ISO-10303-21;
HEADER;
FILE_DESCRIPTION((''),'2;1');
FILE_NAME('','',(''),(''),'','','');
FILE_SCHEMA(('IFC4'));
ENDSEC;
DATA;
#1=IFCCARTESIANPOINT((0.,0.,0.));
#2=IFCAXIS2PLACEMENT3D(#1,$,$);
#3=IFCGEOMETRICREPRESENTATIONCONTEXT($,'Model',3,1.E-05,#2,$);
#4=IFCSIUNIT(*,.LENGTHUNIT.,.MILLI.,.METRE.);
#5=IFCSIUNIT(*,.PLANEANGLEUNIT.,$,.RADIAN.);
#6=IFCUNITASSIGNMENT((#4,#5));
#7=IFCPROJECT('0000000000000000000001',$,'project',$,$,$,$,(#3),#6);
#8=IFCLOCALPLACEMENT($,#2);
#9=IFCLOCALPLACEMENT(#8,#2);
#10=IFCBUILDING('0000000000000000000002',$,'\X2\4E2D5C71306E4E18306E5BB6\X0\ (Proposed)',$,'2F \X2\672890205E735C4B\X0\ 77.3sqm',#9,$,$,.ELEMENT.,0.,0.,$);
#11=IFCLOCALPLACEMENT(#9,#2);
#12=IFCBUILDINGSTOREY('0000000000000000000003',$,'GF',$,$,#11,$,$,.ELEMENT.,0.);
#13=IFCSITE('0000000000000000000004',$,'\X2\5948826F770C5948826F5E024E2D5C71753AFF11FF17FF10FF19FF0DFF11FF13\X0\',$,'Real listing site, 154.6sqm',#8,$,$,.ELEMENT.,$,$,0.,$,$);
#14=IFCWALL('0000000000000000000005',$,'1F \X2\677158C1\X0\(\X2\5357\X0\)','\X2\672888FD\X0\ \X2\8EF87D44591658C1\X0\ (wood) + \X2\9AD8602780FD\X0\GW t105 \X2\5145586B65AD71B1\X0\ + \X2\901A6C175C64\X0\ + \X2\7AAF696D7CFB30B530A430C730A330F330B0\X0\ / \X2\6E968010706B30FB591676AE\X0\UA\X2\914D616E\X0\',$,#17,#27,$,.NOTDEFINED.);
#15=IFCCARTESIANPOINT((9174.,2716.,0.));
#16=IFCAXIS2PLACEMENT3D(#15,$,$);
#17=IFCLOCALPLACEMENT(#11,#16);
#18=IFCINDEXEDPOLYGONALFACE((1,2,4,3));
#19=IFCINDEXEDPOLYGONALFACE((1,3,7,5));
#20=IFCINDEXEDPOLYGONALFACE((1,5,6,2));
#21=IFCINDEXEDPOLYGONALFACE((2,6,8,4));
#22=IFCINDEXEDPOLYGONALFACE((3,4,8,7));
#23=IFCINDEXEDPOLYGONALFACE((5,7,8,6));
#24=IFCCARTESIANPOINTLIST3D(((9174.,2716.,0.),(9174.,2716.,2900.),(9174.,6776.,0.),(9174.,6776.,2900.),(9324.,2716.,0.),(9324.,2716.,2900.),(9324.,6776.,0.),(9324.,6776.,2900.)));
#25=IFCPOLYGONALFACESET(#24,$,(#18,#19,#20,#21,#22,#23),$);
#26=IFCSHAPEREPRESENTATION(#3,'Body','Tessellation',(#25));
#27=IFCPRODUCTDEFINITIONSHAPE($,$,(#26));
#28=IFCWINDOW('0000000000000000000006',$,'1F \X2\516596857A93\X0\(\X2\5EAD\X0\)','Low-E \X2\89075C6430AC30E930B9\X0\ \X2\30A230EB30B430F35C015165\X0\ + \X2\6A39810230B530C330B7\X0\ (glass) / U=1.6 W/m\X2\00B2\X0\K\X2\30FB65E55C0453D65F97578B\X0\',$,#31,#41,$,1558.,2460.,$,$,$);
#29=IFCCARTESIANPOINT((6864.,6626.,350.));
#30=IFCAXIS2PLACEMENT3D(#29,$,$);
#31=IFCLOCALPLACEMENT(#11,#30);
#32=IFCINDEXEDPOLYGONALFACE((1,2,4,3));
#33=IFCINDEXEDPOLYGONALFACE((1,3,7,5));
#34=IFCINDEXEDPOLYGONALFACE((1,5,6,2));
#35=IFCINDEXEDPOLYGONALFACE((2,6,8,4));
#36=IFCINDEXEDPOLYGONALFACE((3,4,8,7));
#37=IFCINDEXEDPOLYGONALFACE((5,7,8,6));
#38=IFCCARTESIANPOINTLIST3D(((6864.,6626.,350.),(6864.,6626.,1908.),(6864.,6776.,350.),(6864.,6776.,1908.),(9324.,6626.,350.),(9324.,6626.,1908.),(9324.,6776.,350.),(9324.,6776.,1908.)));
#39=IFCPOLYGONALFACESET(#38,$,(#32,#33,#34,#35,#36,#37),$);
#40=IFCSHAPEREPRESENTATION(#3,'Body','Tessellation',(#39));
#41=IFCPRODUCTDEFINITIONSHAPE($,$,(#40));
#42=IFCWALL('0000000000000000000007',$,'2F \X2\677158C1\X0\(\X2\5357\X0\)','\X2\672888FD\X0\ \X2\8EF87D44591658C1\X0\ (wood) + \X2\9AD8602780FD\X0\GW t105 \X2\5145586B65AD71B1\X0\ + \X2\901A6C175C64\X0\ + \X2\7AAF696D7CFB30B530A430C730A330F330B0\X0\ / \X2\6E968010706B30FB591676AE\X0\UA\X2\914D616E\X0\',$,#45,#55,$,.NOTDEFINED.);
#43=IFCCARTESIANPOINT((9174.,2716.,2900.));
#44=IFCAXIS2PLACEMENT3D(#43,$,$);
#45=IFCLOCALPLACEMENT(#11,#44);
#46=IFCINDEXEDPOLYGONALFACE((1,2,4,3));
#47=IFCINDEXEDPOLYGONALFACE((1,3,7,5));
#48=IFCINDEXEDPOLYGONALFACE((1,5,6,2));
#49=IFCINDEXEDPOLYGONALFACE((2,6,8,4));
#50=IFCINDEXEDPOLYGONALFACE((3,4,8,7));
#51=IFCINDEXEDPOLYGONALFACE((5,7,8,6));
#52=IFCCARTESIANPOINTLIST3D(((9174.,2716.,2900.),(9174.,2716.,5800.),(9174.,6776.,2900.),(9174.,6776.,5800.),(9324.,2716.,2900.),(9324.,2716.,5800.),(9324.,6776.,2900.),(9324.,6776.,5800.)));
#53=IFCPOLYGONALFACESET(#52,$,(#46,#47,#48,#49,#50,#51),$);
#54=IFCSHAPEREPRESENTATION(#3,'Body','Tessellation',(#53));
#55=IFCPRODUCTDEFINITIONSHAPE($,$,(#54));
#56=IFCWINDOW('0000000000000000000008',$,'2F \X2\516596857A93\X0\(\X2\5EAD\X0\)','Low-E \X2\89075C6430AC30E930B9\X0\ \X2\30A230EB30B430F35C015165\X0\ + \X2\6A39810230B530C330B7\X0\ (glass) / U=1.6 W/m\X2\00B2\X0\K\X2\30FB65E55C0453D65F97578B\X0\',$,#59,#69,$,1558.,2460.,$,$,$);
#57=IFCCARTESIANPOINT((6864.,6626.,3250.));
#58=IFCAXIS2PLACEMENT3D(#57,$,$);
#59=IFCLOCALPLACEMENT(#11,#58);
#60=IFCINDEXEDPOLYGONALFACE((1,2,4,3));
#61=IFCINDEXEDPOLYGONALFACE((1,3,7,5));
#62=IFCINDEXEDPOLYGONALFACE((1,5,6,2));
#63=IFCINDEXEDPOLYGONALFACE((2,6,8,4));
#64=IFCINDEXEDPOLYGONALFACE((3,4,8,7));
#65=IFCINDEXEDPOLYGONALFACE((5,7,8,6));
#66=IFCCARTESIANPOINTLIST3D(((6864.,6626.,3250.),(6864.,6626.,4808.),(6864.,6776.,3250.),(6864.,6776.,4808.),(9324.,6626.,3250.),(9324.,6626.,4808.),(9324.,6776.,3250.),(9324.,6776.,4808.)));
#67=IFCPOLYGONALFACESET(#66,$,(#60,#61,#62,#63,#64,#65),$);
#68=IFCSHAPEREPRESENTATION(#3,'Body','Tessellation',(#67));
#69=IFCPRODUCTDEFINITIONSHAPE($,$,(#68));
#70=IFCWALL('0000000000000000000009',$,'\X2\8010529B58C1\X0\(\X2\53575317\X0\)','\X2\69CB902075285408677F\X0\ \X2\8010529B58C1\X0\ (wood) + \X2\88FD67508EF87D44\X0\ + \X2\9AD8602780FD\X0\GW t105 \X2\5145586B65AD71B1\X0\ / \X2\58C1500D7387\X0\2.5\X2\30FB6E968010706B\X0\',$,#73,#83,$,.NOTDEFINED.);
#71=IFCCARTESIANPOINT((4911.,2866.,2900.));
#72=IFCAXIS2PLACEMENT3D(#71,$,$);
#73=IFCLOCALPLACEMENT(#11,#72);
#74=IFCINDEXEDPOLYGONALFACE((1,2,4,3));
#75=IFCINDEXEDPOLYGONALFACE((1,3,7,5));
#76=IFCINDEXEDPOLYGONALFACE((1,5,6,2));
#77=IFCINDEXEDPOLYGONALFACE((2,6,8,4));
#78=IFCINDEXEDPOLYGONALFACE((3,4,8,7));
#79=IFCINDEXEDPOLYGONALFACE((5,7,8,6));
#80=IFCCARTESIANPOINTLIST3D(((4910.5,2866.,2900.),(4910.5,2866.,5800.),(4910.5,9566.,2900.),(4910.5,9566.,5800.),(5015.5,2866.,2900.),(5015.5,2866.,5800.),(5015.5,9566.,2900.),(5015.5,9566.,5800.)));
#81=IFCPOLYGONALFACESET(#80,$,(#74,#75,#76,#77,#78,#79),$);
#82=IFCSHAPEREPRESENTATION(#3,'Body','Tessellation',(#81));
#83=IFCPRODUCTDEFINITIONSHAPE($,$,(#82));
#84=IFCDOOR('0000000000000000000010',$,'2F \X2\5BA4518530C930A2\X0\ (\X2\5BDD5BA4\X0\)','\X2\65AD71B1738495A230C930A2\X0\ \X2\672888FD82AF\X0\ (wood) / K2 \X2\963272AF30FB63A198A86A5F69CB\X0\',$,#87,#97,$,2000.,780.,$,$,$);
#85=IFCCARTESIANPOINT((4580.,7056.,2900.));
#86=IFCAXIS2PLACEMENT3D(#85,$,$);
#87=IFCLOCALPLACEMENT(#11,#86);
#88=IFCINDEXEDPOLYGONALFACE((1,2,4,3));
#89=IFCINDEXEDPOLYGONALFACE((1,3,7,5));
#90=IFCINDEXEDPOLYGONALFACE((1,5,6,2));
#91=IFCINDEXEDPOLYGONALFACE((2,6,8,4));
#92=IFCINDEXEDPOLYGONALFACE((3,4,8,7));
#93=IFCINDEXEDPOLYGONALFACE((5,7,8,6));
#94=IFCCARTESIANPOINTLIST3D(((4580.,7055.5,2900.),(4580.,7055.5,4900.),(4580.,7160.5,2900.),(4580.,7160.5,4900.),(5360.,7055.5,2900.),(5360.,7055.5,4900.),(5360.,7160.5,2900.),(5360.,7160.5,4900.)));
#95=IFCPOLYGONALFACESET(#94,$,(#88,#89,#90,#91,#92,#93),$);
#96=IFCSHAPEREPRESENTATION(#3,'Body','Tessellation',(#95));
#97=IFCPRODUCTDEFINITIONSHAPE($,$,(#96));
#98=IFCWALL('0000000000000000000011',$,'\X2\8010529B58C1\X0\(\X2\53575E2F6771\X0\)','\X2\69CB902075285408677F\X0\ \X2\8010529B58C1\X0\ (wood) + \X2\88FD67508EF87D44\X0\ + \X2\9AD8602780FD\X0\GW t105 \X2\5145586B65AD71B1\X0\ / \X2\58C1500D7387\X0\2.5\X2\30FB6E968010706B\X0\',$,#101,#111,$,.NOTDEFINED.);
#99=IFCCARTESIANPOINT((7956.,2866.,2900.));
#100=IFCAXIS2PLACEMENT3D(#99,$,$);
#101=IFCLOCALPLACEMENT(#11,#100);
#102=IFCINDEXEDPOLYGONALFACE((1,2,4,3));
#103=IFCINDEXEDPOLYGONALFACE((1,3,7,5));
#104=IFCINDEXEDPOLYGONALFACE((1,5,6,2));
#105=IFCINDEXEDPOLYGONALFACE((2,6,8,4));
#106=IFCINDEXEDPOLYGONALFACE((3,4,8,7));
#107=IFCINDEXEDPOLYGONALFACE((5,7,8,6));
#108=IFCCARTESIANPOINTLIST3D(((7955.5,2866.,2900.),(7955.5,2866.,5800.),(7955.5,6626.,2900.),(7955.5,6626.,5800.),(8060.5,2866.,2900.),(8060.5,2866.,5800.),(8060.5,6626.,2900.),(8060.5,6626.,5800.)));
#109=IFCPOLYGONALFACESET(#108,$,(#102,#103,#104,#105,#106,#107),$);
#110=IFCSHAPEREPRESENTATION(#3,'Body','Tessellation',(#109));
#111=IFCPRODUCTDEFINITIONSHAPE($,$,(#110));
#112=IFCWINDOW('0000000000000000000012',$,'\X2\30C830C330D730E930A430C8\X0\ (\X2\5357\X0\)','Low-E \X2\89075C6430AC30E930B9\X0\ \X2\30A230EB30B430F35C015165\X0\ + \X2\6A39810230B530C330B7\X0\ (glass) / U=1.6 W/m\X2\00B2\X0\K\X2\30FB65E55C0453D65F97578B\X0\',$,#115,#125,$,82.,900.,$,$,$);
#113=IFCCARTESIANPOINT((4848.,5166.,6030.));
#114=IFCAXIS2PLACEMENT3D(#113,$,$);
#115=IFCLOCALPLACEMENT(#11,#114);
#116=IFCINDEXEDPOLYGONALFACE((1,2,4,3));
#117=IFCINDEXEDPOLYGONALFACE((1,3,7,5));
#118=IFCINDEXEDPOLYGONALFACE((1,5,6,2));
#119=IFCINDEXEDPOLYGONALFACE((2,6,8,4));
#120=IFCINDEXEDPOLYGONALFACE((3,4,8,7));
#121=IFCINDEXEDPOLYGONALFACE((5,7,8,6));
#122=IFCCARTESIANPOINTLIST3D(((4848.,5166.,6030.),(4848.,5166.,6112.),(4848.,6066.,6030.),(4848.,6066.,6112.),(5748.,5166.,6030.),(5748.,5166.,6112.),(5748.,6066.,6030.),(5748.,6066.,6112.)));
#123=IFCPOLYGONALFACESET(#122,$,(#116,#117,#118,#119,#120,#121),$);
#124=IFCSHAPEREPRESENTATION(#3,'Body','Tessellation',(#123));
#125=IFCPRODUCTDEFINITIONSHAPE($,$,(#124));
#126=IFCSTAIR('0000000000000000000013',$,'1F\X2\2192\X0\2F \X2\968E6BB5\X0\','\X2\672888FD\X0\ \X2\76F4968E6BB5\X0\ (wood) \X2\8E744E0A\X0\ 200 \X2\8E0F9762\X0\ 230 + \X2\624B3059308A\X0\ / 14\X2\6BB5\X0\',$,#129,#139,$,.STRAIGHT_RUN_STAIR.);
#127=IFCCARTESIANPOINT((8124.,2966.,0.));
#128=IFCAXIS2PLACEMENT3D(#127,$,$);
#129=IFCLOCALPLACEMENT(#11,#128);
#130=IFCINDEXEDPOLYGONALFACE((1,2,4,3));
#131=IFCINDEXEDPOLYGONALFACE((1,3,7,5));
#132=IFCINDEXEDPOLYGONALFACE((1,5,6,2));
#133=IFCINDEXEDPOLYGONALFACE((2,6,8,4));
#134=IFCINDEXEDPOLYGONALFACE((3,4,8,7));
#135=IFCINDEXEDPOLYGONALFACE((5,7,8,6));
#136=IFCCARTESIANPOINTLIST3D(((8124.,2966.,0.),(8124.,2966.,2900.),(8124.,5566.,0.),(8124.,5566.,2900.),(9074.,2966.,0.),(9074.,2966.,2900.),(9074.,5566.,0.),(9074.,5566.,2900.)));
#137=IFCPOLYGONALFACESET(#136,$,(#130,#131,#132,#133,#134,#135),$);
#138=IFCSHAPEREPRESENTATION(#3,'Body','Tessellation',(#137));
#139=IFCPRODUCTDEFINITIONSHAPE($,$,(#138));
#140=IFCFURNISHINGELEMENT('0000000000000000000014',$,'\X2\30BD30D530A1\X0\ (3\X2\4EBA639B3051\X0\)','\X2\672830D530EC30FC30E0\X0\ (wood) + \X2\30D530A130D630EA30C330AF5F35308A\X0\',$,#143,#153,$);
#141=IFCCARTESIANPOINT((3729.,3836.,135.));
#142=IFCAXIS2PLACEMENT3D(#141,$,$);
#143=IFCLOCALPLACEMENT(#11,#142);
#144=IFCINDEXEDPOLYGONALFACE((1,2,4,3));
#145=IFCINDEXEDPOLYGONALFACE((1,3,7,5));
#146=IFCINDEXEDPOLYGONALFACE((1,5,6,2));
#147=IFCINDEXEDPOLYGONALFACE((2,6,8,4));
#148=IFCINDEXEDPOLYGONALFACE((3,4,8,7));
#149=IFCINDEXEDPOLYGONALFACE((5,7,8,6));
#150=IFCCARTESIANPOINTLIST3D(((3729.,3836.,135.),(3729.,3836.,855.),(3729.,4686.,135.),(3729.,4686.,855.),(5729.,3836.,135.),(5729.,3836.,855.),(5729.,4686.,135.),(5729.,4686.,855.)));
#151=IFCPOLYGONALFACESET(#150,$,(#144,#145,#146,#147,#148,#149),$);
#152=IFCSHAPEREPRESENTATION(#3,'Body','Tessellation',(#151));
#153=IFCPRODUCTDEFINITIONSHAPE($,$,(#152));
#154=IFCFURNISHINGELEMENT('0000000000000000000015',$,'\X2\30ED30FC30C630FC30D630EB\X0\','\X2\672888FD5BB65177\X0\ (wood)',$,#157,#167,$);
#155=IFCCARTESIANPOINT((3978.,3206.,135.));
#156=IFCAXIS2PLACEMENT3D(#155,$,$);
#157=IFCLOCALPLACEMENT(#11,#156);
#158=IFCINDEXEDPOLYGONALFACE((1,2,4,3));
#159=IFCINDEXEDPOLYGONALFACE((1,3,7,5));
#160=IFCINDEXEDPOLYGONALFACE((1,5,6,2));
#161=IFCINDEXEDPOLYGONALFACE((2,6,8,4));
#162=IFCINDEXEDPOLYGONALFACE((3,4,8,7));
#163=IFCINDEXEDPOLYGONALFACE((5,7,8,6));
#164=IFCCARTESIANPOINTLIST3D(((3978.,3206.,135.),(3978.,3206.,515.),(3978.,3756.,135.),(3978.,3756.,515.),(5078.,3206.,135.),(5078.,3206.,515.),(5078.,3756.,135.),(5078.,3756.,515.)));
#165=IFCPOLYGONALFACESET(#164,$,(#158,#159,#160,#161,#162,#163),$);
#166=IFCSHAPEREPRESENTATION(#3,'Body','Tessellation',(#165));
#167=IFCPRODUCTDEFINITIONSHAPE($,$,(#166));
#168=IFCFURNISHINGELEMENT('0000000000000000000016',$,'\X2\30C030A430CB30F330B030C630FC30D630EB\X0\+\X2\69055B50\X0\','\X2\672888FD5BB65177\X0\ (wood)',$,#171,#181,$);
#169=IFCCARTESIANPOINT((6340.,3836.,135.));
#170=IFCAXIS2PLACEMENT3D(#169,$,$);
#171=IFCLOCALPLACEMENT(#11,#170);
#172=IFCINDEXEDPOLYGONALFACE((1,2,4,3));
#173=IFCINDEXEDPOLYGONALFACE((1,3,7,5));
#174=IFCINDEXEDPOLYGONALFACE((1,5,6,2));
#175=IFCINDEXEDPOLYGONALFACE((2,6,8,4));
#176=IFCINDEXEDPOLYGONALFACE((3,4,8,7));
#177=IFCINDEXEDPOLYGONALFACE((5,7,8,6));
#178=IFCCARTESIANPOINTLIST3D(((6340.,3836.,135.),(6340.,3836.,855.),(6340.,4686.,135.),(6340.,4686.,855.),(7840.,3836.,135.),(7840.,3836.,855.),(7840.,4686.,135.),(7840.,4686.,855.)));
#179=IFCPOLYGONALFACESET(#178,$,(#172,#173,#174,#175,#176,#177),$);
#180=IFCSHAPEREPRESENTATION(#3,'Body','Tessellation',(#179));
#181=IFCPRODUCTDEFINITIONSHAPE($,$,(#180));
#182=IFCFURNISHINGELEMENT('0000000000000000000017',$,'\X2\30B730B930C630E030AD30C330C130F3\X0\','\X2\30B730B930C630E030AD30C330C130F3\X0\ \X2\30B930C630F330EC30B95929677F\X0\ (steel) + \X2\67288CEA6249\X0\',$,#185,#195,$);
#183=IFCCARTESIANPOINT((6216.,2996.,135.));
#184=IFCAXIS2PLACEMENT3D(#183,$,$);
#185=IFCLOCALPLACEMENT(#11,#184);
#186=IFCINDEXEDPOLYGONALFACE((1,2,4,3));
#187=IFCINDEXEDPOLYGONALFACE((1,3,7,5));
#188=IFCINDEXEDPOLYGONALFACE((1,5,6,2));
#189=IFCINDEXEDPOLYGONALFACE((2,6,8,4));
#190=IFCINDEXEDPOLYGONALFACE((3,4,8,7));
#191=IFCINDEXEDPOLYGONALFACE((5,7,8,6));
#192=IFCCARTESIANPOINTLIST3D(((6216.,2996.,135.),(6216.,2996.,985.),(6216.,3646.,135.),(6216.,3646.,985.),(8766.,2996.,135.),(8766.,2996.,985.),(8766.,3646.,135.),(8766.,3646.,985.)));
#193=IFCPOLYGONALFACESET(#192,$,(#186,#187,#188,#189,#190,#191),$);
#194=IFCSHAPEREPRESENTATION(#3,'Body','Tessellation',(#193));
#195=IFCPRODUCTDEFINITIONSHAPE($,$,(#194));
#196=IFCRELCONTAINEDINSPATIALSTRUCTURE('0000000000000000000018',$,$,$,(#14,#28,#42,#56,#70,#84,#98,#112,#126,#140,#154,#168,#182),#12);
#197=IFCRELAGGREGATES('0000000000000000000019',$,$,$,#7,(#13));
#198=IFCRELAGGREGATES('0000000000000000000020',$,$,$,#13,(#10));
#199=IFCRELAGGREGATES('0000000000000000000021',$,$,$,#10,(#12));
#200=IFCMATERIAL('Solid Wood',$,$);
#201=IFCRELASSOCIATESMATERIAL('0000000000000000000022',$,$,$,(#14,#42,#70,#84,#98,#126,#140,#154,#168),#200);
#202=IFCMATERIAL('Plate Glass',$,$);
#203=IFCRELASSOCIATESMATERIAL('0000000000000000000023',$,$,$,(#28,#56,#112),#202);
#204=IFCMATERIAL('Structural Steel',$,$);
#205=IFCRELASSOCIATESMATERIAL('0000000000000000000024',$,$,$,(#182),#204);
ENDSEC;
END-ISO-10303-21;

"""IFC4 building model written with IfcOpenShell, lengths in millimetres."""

from ifc_helpers import new_model, si_unit, frame, frame_2d, origin, place, context, project, spatial, rectangle, extrude, material, element, fill, save


model = new_model("IFC4")

# Units and contexts
model_context = context("Model", 3, precision=1e-05, world=origin())
ifc_project = project(units=[si_unit("LENGTHUNIT", "METRE", prefix="MILLI"), si_unit("PLANEANGLEUNIT", "RADIAN")], contexts=[model_context])

# Site, building, storey
site_placement = place(None, origin())
site = spatial("IfcSite", under=ifc_project, at=site_placement, Name="奈良県奈良市中山町１７０９－１３", ObjectType="Real listing site, 154.6sqm", CompositionType="ELEMENT", RefElevation=0.0)
building_placement = place(site_placement, origin())
building = spatial("IfcBuilding", under=site, at=building_placement, Name="中山の丘の家 (Proposed)", ObjectType="2F 木造平屋 77.3sqm", CompositionType="ELEMENT", ElevationOfRefHeight=0.0, ElevationOfTerrain=0.0)
storey_placement = place(building_placement, origin())
storey = spatial("IfcBuildingStorey", under=building, at=storey_placement, Name="GF", CompositionType="ELEMENT", Elevation=0.0)

# Wall, opening, window
ifc_material_1 = material(Name="Solid Wood")
wall_1_placement = place(storey_placement, frame((9174.0, 2716.0, 0.0)))
wall_1 = element("IfcWall", 1, at=wall_1_placement, inside=storey, material=ifc_material_1, Name="1F 東壁(南)", Description="木製 軸組外壁 (wood) + 高性能GW t105 充填断熱 + 通気層 + 窯業系サイディング / 準耐火・外皮UA配慮", PredefinedType="NOTDEFINED", context=model_context, shape_type="SweptSolid", body=[
    extrude(rectangle(XDim=150.0, YDim=4060.0, at=frame_2d((75.0, 2030.0))), frame((9174.0, 2716.0, 0.0)), (0.0, 0.0, 1.0), 2900.0),
])
opening_1_placement = place(storey_placement, frame((6864.0, 6626.0, 350.0)))
opening_1 = element("IfcOpeningElement", 2, at=opening_1_placement, cuts=wall_1, PredefinedType="NOTDEFINED", context=model_context, shape_type="SweptSolid", body=[
    extrude(rectangle(XDim=2460.0, YDim=150.0, at=frame_2d((1230.0, 75.0))), frame((6864.0, 6626.0, 350.0)), (0.0, 0.0, 1.0), 1558.0),
])
ifc_material_2 = material(Name="Plate Glass")
window_1_placement = place(storey_placement, frame((6864.0, 6626.0, 350.0)))
window_1 = element("IfcWindow", 3, at=window_1_placement, inside=storey, material=ifc_material_2, Name="1F 入隅窓(庭)", Description="Low-E 複層ガラス アルゴン封入 + 樹脂サッシ (glass) / U=1.6 W/m²K・日射取得型", OverallHeight=1558.0, OverallWidth=2460.0, context=model_context, shape_type="SweptSolid", body=[
    extrude(rectangle(XDim=2460.0, YDim=150.0, at=frame_2d((1230.0, 75.0))), frame((6864.0, 6626.0, 350.0)), (0.0, 0.0, 1.0), 1558.0),
])
fill(opening_1, window_1)

# Wall, opening, window
wall_2_placement = place(storey_placement, frame((9174.0, 2716.0, 2900.0)))
wall_2 = element("IfcWall", 4, at=wall_2_placement, inside=storey, material=ifc_material_1, Name="2F 東壁(南)", Description="木製 軸組外壁 (wood) + 高性能GW t105 充填断熱 + 通気層 + 窯業系サイディング / 準耐火・外皮UA配慮", PredefinedType="NOTDEFINED", context=model_context, shape_type="SweptSolid", body=[
    extrude(rectangle(XDim=150.0, YDim=4060.0, at=frame_2d((75.0, 2030.0))), frame((9174.0, 2716.0, 2900.0)), (0.0, 0.0, 1.0), 2900.0),
])
opening_2_placement = place(storey_placement, frame((6864.0, 6626.0, 3250.0)))
opening_2 = element("IfcOpeningElement", 5, at=opening_2_placement, cuts=wall_2, PredefinedType="NOTDEFINED", context=model_context, shape_type="SweptSolid", body=[
    extrude(rectangle(XDim=2460.0, YDim=150.0, at=frame_2d((1230.0, 75.0))), frame((6864.0, 6626.0, 3250.0)), (0.0, 0.0, 1.0), 1558.0),
])
window_2_placement = place(storey_placement, frame((6864.0, 6626.0, 3250.0)))
window_2 = element("IfcWindow", 6, at=window_2_placement, inside=storey, material=ifc_material_2, Name="2F 入隅窓(庭)", Description="Low-E 複層ガラス アルゴン封入 + 樹脂サッシ (glass) / U=1.6 W/m²K・日射取得型", OverallHeight=1558.0, OverallWidth=2460.0, context=model_context, shape_type="SweptSolid", body=[
    extrude(rectangle(XDim=2460.0, YDim=150.0, at=frame_2d((1230.0, 75.0))), frame((6864.0, 6626.0, 3250.0)), (0.0, 0.0, 1.0), 1558.0),
])
fill(opening_2, window_2)

# Wall, opening, door
wall_3_placement = place(storey_placement, frame((4911.0, 2866.0, 2900.0)))
wall_3 = element("IfcWall", 7, at=wall_3_placement, inside=storey, material=ifc_material_1, Name="耐力壁(南北)", Description="構造用合板 耐力壁 (wood) + 製材軸組 + 高性能GW t105 充填断熱 / 壁倍率2.5・準耐火", PredefinedType="NOTDEFINED", context=model_context, shape_type="SweptSolid", body=[
    extrude(rectangle(XDim=105.0, YDim=6700.0, at=frame_2d((52.0, 3350.0))), frame((4911.0, 2866.0, 2900.0)), (0.0, 0.0, 1.0), 2900.0),
])
opening_3_placement = place(storey_placement, frame((4580.0, 7056.0, 2900.0)))
opening_3 = element("IfcOpeningElement", 8, at=opening_3_placement, cuts=wall_3, PredefinedType="NOTDEFINED", context=model_context, shape_type="SweptSolid", body=[
    extrude(rectangle(XDim=780.0, YDim=105.0, at=frame_2d((390.0, 52.0))), frame((4580.0, 7056.0, 2900.0)), (0.0, 0.0, 1.0), 2000.0),
])
door_1_placement = place(storey_placement, frame((4580.0, 7056.0, 2900.0)))
door_1 = element("IfcDoor", 9, at=door_1_placement, inside=storey, material=ifc_material_1, Name="2F 室内ドア (寝室)", Description="断熱玄関ドア 木製芯 (wood) / K2 防犯・採風機構", OverallHeight=2000.0, OverallWidth=780.0, context=model_context, shape_type="SweptSolid", body=[
    extrude(rectangle(XDim=780.0, YDim=105.0, at=frame_2d((390.0, 52.0))), frame((4580.0, 7056.0, 2900.0)), (0.0, 0.0, 1.0), 2000.0),
])
fill(opening_3, door_1)

# Wall
wall_4_placement = place(storey_placement, frame((7956.0, 2866.0, 2900.0)))
element("IfcWall", 10, at=wall_4_placement, inside=storey, material=ifc_material_1, Name="耐力壁(南帯東)", Description="構造用合板 耐力壁 (wood) + 製材軸組 + 高性能GW t105 充填断熱 / 壁倍率2.5・準耐火", PredefinedType="NOTDEFINED", context=model_context, shape_type="SweptSolid", body=[
    extrude(rectangle(XDim=105.0, YDim=3760.0, at=frame_2d((52.0, 1880.0))), frame((7956.0, 2866.0, 2900.0)), (0.0, 0.0, 1.0), 2900.0),
])

# Window
window_3_placement = place(storey_placement, frame((4848.0, 5166.0, 6030.0)))
element("IfcWindow", 11, at=window_3_placement, inside=storey, material=ifc_material_2, Name="トップライト (南)", Description="Low-E 複層ガラス アルゴン封入 + 樹脂サッシ (glass) / U=1.6 W/m²K・日射取得型", OverallHeight=82.0, OverallWidth=900.0, context=model_context, shape_type="SweptSolid", body=[
    extrude(rectangle(XDim=900.0, YDim=900.0, at=frame_2d((450.0, 450.0))), frame((4848.0, 5166.0, 6030.0)), (0.0, 0.0, 1.0), 82.0),
])

# Stair
stair_placement = place(storey_placement, frame((8124.0, 2966.0, 0.0)))
element("IfcStair", 12, at=stair_placement, inside=storey, material=ifc_material_1, Name="1F→2F 階段", Description="木製 直階段 (wood) 蹴上 200 踏面 230 + 手すり / 14段", PredefinedType="STRAIGHT_RUN_STAIR", context=model_context, shape_type="SweptSolid", body=[
    extrude(rectangle(XDim=950.0, YDim=2600.0, at=frame_2d((475.0, 1300.0))), frame((8124.0, 2966.0, 0.0)), (0.0, 0.0, 1.0), 2900.0),
])

# Furnishing elements
furnishing_1_placement = place(storey_placement, frame((3729.0, 3836.0, 135.0)))
element("IfcFurnishingElement", 13, at=furnishing_1_placement, inside=storey, material=ifc_material_1, Name="ソファ (3人掛け)", Description="木フレーム (wood) + ファブリック張り", context=model_context, shape_type="SweptSolid", body=[
    extrude(rectangle(XDim=2000.0, YDim=850.0, at=frame_2d((1000.0, 425.0))), frame((3729.0, 3836.0, 135.0)), (0.0, 0.0, 1.0), 720.0),
])
furnishing_2_placement = place(storey_placement, frame((3978.0, 3206.0, 135.0)))
element("IfcFurnishingElement", 14, at=furnishing_2_placement, inside=storey, material=ifc_material_1, Name="ローテーブル", Description="木製家具 (wood)", context=model_context, shape_type="SweptSolid", body=[
    extrude(rectangle(XDim=1100.0, YDim=550.0, at=frame_2d((550.0, 275.0))), frame((3978.0, 3206.0, 135.0)), (0.0, 0.0, 1.0), 380.0),
])
furnishing_3_placement = place(storey_placement, frame((6340.0, 3836.0, 135.0)))
element("IfcFurnishingElement", 15, at=furnishing_3_placement, inside=storey, material=ifc_material_1, Name="ダイニングテーブル+椅子", Description="木製家具 (wood)", context=model_context, shape_type="SweptSolid", body=[
    extrude(rectangle(XDim=1500.0, YDim=850.0, at=frame_2d((750.0, 425.0))), frame((6340.0, 3836.0, 135.0)), (0.0, 0.0, 1.0), 720.0),
])
ifc_material_3 = material(Name="Structural Steel")
furnishing_4_placement = place(storey_placement, frame((6216.0, 2996.0, 135.0)))
element("IfcFurnishingElement", 16, at=furnishing_4_placement, inside=storey, material=ifc_material_3, Name="システムキッチン", Description="システムキッチン ステンレス天板 (steel) + 木質扉", context=model_context, shape_type="SweptSolid", body=[
    extrude(rectangle(XDim=2550.0, YDim=650.0, at=frame_2d((1275.0, 325.0))), frame((6216.0, 2996.0, 135.0)), (0.0, 0.0, 1.0), 850.0),
])

save(model, "model.ifc")
